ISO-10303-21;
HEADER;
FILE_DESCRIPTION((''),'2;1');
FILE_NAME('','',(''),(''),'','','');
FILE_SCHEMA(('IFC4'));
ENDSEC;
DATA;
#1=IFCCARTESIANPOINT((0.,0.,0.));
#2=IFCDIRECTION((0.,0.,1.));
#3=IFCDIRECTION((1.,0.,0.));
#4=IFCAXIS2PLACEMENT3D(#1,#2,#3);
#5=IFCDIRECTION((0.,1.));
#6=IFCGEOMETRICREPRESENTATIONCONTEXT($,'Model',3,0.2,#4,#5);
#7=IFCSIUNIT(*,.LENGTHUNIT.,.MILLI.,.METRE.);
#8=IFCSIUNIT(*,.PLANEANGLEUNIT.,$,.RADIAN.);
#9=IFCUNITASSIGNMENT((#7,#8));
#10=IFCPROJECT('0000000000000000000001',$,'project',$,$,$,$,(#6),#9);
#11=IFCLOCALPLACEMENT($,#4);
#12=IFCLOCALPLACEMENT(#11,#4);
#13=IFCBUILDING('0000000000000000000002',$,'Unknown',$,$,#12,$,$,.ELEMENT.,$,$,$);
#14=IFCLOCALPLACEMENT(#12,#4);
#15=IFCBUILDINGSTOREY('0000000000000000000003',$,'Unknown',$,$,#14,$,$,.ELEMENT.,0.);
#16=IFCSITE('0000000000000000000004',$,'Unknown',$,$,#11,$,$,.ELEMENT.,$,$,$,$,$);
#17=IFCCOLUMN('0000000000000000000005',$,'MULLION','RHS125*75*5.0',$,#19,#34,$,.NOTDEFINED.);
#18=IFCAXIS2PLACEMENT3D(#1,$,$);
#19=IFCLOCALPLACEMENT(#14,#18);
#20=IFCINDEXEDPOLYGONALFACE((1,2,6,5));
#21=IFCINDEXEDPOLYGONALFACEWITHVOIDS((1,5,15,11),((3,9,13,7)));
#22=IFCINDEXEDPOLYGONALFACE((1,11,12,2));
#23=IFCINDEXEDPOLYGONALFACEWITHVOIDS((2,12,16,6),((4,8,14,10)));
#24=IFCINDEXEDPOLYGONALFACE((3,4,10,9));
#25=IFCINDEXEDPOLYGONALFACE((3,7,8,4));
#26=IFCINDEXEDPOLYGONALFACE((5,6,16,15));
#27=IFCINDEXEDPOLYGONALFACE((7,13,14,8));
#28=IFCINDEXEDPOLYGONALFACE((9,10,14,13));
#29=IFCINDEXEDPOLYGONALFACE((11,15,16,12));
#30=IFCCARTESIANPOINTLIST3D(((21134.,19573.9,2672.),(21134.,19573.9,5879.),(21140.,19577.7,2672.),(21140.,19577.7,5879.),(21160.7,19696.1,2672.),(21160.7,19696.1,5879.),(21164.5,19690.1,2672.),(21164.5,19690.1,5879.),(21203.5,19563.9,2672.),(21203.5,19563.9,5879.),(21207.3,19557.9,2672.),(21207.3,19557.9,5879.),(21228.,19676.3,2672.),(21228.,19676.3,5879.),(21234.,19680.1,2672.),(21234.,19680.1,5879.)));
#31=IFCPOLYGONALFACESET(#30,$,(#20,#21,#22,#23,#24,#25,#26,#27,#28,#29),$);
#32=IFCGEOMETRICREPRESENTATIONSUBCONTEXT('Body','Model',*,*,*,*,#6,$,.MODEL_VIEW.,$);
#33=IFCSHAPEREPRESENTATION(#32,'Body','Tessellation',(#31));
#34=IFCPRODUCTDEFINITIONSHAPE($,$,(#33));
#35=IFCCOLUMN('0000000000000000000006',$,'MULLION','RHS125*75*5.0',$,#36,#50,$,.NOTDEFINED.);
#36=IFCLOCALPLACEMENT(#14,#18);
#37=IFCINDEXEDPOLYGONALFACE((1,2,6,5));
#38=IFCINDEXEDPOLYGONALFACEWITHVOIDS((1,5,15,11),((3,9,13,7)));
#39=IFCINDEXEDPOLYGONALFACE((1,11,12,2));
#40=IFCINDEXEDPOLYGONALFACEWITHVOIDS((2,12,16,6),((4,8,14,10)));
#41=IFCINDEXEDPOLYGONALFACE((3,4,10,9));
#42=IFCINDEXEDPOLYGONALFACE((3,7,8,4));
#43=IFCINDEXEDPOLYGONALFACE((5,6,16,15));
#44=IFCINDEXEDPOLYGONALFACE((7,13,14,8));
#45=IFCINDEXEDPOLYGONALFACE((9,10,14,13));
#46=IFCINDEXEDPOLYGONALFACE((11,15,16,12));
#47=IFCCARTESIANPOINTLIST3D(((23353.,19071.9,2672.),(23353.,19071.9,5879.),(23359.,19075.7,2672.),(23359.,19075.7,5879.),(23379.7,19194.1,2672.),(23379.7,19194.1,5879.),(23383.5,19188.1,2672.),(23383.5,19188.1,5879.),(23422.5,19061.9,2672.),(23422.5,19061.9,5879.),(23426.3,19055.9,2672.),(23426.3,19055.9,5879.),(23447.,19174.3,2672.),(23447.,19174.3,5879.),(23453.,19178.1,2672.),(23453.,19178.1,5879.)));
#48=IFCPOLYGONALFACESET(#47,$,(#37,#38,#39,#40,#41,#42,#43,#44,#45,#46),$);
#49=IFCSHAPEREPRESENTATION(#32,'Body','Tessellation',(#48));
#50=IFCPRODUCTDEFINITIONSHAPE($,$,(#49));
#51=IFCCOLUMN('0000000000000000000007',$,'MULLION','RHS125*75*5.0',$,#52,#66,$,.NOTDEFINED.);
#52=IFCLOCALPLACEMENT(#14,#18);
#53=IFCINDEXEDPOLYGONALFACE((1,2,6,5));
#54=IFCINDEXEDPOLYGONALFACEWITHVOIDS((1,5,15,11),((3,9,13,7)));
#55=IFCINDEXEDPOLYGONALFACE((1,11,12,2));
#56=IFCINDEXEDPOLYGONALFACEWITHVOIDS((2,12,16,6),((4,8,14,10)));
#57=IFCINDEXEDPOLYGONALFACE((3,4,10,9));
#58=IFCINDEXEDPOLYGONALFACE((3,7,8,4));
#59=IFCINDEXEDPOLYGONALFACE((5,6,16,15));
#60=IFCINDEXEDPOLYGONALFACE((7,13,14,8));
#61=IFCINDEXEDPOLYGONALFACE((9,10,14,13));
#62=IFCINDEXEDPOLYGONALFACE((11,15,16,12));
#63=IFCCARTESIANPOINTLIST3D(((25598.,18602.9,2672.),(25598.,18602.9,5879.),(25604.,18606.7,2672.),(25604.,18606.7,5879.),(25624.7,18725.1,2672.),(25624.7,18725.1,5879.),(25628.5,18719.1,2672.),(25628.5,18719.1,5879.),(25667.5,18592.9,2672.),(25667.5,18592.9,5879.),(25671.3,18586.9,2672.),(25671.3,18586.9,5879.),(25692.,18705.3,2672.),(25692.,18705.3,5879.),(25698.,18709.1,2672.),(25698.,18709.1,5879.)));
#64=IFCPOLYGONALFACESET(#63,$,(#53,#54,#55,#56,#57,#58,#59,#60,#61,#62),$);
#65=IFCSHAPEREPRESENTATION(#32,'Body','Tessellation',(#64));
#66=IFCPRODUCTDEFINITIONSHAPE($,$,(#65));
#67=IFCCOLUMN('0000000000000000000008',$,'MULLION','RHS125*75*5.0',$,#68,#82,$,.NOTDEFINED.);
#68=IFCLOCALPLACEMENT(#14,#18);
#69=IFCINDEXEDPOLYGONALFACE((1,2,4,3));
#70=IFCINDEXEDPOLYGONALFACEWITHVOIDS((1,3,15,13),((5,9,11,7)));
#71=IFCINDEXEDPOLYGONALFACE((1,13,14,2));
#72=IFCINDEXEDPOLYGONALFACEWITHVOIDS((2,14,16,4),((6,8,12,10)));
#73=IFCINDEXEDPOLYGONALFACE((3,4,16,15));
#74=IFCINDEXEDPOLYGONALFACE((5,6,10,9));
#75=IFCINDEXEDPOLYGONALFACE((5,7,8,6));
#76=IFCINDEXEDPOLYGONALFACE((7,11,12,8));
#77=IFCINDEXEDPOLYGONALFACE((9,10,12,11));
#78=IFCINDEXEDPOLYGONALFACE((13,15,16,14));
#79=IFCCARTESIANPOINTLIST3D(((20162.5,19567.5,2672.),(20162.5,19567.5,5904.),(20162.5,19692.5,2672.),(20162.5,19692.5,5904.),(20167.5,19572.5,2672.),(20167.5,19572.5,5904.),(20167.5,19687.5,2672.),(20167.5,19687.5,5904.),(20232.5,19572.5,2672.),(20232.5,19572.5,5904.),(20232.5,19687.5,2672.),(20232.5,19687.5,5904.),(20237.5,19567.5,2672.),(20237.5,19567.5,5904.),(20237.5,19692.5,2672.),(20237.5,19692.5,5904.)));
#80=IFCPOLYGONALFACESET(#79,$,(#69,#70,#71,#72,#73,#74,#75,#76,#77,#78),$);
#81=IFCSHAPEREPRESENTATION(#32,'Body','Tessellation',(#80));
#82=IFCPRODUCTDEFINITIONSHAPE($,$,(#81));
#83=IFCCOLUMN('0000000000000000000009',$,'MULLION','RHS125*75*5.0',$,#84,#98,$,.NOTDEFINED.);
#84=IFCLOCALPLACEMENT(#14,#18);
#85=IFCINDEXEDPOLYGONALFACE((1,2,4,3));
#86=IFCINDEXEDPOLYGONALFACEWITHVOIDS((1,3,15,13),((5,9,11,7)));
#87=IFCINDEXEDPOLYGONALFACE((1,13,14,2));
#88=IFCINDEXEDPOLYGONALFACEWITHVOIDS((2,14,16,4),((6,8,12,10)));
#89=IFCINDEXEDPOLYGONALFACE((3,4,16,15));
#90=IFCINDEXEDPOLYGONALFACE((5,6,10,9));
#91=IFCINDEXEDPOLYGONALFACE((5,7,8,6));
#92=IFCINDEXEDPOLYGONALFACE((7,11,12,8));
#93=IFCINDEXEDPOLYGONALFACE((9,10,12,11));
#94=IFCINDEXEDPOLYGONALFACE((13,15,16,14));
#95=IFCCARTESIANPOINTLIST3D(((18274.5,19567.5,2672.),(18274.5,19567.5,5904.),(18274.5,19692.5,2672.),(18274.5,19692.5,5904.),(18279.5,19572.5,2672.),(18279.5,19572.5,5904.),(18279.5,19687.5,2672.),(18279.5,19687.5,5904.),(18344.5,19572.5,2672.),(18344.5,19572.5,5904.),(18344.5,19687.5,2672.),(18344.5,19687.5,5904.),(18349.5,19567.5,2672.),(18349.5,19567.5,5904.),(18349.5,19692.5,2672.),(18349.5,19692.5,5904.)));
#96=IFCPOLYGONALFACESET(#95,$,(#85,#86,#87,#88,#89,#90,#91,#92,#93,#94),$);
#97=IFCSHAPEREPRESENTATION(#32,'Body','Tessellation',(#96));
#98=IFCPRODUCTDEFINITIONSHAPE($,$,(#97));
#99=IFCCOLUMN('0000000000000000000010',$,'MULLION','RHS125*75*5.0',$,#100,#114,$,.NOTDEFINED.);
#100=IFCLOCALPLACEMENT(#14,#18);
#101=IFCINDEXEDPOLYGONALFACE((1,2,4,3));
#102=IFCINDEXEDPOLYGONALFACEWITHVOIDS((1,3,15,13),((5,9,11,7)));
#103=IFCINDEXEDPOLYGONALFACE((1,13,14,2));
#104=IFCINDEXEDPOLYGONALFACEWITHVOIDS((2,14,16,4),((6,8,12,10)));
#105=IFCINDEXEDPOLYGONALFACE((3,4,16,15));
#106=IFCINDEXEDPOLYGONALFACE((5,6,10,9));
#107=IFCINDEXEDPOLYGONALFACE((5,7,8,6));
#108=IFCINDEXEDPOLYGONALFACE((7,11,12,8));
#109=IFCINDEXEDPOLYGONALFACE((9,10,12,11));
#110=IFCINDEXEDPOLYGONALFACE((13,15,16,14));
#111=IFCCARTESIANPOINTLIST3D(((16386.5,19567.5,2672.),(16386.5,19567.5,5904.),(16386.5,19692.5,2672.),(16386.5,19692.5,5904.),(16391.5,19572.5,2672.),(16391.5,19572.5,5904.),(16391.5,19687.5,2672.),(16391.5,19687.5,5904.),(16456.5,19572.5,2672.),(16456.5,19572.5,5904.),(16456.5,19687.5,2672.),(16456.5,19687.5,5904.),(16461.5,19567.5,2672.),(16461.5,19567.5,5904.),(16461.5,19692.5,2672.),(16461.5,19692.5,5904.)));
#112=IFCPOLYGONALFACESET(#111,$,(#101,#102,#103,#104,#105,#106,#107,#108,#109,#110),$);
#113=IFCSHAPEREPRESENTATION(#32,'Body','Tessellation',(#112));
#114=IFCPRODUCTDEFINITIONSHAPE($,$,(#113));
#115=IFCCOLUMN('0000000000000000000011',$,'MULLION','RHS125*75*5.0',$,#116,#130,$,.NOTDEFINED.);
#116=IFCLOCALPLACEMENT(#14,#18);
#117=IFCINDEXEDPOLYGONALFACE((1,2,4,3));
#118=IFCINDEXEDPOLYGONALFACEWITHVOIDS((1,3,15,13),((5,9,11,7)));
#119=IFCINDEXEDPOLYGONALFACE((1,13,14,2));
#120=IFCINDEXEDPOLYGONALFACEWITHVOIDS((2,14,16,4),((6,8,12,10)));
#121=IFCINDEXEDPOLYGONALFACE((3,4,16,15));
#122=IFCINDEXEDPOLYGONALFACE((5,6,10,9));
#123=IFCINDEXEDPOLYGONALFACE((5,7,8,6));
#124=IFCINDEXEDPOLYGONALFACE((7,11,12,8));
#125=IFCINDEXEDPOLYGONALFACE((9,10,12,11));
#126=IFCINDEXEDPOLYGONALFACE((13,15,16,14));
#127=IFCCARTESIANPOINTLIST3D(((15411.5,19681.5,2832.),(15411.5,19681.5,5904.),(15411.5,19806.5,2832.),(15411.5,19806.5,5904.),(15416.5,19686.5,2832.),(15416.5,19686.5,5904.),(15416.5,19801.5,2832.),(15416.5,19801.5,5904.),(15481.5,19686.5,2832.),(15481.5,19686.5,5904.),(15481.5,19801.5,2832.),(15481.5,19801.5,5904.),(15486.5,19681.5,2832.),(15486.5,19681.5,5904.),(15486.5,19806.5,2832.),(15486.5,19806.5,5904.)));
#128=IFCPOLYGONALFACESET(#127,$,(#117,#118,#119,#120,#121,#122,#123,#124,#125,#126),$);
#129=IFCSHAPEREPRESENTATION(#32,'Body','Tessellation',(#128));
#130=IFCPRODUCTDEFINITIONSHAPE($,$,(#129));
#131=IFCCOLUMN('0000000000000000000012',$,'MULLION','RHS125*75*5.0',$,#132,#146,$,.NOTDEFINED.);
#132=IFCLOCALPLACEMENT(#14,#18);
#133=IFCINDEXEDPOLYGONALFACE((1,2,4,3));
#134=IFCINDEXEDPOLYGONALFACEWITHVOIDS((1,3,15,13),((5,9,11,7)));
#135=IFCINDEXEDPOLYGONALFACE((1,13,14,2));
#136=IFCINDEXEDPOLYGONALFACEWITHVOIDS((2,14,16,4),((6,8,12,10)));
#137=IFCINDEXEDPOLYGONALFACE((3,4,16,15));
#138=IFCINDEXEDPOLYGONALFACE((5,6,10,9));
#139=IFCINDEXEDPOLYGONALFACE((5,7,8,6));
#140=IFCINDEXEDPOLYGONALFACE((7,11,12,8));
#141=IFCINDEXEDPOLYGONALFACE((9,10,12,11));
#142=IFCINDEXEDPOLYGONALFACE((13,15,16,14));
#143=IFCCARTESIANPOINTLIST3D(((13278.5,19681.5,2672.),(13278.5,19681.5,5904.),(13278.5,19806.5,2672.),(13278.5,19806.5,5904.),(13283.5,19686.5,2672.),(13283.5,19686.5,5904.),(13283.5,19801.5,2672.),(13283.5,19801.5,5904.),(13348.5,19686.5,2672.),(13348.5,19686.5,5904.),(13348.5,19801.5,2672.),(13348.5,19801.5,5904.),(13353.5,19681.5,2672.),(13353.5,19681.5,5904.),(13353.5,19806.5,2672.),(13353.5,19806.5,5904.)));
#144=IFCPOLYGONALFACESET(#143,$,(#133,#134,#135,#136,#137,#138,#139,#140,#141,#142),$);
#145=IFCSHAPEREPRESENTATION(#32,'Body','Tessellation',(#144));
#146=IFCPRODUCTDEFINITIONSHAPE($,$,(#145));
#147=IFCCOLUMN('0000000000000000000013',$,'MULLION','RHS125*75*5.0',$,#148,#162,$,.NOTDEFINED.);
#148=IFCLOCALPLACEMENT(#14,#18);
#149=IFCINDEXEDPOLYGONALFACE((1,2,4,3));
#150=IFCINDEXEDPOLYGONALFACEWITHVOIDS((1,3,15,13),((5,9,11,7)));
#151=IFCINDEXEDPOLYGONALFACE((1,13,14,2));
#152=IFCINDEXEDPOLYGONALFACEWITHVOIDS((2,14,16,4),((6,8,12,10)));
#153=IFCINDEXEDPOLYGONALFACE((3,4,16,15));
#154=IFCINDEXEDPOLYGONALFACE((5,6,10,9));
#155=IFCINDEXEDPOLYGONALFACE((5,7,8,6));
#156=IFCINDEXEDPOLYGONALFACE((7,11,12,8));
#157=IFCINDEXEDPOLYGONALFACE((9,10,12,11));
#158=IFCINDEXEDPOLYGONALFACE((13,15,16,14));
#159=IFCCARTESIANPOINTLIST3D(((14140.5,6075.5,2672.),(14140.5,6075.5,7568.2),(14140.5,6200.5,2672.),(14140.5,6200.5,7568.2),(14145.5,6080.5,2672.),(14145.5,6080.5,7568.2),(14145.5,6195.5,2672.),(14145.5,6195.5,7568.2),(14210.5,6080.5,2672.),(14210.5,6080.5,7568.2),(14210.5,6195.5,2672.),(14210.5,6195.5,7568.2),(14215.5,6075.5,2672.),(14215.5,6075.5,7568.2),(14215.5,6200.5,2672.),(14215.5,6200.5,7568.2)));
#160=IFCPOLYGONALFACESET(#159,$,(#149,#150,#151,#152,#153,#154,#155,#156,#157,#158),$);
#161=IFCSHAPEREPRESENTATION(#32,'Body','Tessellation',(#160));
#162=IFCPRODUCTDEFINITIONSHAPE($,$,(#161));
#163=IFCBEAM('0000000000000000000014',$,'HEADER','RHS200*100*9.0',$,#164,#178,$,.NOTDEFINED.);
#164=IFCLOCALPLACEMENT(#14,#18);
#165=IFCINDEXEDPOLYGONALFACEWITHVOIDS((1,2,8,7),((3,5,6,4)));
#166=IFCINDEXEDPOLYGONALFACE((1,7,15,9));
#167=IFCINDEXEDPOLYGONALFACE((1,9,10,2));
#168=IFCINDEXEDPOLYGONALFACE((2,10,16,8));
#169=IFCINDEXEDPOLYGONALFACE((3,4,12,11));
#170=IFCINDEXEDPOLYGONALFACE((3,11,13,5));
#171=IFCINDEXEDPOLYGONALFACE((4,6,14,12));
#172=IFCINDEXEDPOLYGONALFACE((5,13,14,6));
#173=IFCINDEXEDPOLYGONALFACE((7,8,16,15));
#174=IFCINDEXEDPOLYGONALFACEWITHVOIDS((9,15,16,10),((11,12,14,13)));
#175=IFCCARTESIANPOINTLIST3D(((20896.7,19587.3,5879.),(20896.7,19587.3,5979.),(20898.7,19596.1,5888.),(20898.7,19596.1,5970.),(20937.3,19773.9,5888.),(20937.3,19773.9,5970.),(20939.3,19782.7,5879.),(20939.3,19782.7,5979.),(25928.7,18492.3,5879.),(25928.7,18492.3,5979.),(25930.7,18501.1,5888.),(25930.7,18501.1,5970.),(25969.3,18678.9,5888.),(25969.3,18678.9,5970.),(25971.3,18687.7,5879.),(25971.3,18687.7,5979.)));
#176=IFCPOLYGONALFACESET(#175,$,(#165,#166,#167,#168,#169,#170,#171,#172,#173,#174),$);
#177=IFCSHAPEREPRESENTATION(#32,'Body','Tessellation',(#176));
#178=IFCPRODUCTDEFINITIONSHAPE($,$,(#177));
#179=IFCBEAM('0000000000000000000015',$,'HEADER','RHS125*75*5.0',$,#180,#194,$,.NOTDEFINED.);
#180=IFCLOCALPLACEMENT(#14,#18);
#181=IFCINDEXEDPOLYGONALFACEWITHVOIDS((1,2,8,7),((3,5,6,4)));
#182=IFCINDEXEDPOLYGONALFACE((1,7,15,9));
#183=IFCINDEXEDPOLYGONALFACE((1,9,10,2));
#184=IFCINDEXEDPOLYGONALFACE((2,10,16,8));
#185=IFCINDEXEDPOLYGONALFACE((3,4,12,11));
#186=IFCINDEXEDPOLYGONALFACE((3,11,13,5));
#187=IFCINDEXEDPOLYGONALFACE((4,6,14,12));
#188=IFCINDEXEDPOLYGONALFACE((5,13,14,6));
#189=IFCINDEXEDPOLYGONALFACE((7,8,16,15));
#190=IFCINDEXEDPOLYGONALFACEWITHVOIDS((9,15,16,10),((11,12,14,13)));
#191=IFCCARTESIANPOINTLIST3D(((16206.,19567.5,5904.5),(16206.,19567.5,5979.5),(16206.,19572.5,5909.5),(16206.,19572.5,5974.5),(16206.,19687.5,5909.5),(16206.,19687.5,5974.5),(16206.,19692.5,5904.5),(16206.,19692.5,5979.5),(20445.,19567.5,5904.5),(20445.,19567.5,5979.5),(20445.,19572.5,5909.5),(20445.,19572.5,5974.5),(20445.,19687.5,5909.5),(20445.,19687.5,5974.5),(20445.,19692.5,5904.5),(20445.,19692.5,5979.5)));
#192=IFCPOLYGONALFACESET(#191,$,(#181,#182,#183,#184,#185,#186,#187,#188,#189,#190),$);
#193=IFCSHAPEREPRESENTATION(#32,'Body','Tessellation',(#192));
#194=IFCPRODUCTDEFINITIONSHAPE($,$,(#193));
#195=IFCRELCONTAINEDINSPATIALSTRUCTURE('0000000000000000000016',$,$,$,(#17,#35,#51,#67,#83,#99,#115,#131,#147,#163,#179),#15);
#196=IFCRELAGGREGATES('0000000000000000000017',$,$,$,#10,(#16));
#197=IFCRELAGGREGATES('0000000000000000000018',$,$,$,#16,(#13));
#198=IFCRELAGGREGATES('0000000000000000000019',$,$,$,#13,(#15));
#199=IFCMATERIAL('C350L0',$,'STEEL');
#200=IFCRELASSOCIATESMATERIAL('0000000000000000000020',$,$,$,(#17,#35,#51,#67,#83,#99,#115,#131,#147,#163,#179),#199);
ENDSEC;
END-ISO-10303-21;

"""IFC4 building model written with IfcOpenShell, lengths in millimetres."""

from ifc_helpers import new_model, si_unit, direction, frame, origin_with_axes, place, context, subcontext, project, spatial, line, indexed_curve, outline, extrude, material, element, save


model = new_model("IFC4")

# Units and contexts
model_context = context("Model", 3, precision=0.2, world=origin_with_axes(), true_north=direction((0.0, 1.0)))
body_context = subcontext(model_context, "Body", "Model", "MODEL_VIEW")
ifc_project = project(units=[si_unit("LENGTHUNIT", "METRE", prefix="MILLI"), si_unit("PLANEANGLEUNIT", "RADIAN")], contexts=[model_context])

# Site, building, storey
site_placement = place(None, origin_with_axes())
site = spatial("IfcSite", under=ifc_project, at=site_placement, Name="Unknown", CompositionType="ELEMENT")
building_placement = place(site_placement, origin_with_axes())
building = spatial("IfcBuilding", under=site, at=building_placement, Name="Unknown", CompositionType="ELEMENT")
storey_placement = place(building_placement, origin_with_axes())
storey = spatial("IfcBuildingStorey", under=building, at=storey_placement, Name="Unknown", CompositionType="ELEMENT", Elevation=0.0)

# Columns
ifc_material_1 = material(Name="C350L0", Category="STEEL")
for number, where, z_axis, x_axis, name in (
    (1, (21184.0, 19627.0, 2672.0), (0.977046, -0.21303, 0.0), (0.0, 0.0, 1.0), "MULLION"),
    (2, (23403.0, 19125.0, 2672.0), (0.977046, -0.21303, 0.0), (0.0, 0.0, 1.0), "MULLION"),
    (3, (25648.0, 18656.0, 2672.0), (0.977046, -0.21303, 0.0), (0.0, 0.0, 1.0), "MULLION"),
):
    element("IfcColumn", number, at=place(storey_placement, frame(where, z_axis=z_axis, x_axis=x_axis)), inside=storey, material=ifc_material_1, Name=name, Description="RHS125*75*5.0", PredefinedType="NOTDEFINED", context=body_context, shape_type="SolidModel", body=[
        extrude(outline(indexed_curve([(-37.5, -62.5), (37.5, -62.5), (37.5, 62.5), (-37.5, 62.5)], segments=[line(1, 2, 3, 4, 1)]), holes=[indexed_curve([(-32.5, -57.5), (-32.5, 57.5), (32.5, 57.5), (32.5, -57.5)], segments=[line(1, 2, 3, 4, 1)])]), frame((0.0, 0.0, 0.0), z_axis=(-1.0, 0.0, 0.0), x_axis=(0.0, 0.0, 1.0)), (0.0, 0.0, -1.0), 3207.0),
    ])
for number, where, z_axis, x_axis, name in (
    (4, (20200.0, 19630.0, 2672.0), (1.0, 0.0, 0.0), (0.0, 0.0, 1.0), "MULLION"),
    (5, (18312.0, 19630.0, 2672.0), (1.0, 0.0, 0.0), (0.0, 0.0, 1.0), "MULLION"),
    (6, (16424.0, 19630.0, 2672.0), (1.0, 0.0, 0.0), (0.0, 0.0, 1.0), "MULLION"),
):
    element("IfcColumn", number, at=place(storey_placement, frame(where, z_axis=z_axis, x_axis=x_axis)), inside=storey, material=ifc_material_1, Name=name, Description="RHS125*75*5.0", PredefinedType="NOTDEFINED", context=body_context, shape_type="SolidModel", body=[
        extrude(outline(indexed_curve([(-37.5, -62.5), (37.5, -62.5), (37.5, 62.5), (-37.5, 62.5)], segments=[line(1, 2, 3, 4, 1)]), holes=[indexed_curve([(-32.5, -57.5), (-32.5, 57.5), (32.5, 57.5), (32.5, -57.5)], segments=[line(1, 2, 3, 4, 1)])]), frame((0.0, 0.0, 0.0), z_axis=(-1.0, 0.0, 0.0), x_axis=(0.0, 0.0, 1.0)), (0.0, 0.0, -1.0), 3232.0),
    ])
column_1_placement = place(storey_placement, frame((15449.0, 19744.0, 2832.0), z_axis=(1.0, 0.0, 0.0), x_axis=(0.0, 0.0, 1.0)))
element("IfcColumn", 7, at=column_1_placement, inside=storey, material=ifc_material_1, Name="MULLION", Description="RHS125*75*5.0", PredefinedType="NOTDEFINED", context=body_context, shape_type="SolidModel", body=[
    extrude(outline(indexed_curve([(-37.5, -62.5), (37.5, -62.5), (37.5, 62.5), (-37.5, 62.5)], segments=[line(1, 2, 3, 4, 1)]), holes=[indexed_curve([(-32.5, -57.5), (-32.5, 57.5), (32.5, 57.5), (32.5, -57.5)], segments=[line(1, 2, 3, 4, 1)])]), frame((0.0, 0.0, 0.0), z_axis=(-1.0, 0.0, 0.0), x_axis=(0.0, 0.0, 1.0)), (0.0, 0.0, -1.0), 3072.0),
])
column_2_placement = place(storey_placement, frame((13316.0, 19744.0, 2672.0), z_axis=(1.0, 0.0, 0.0), x_axis=(0.0, 0.0, 1.0)))
element("IfcColumn", 8, at=column_2_placement, inside=storey, material=ifc_material_1, Name="MULLION", Description="RHS125*75*5.0", PredefinedType="NOTDEFINED", context=body_context, shape_type="SolidModel", body=[
    extrude(outline(indexed_curve([(-37.5, -62.5), (37.5, -62.5), (37.5, 62.5), (-37.5, 62.5)], segments=[line(1, 2, 3, 4, 1)]), holes=[indexed_curve([(-32.5, -57.5), (-32.5, 57.5), (32.5, 57.5), (32.5, -57.5)], segments=[line(1, 2, 3, 4, 1)])]), frame((0.0, 0.0, 0.0), z_axis=(-1.0, 0.0, 0.0), x_axis=(0.0, 0.0, 1.0)), (0.0, 0.0, -1.0), 3232.0),
])
column_3_placement = place(storey_placement, frame((14178.0, 6138.0, 2672.0), z_axis=(1.0, 0.0, 0.0), x_axis=(0.0, 0.0, 1.0)))
element("IfcColumn", 9, at=column_3_placement, inside=storey, material=ifc_material_1, Name="MULLION", Description="RHS125*75*5.0", PredefinedType="NOTDEFINED", context=body_context, shape_type="SolidModel", body=[
    extrude(outline(indexed_curve([(-37.5, -62.5), (37.5, -62.5), (37.5, 62.5), (-37.5, 62.5)], segments=[line(1, 2, 3, 4, 1)]), holes=[indexed_curve([(-32.5, -57.5), (-32.5, 57.5), (32.5, 57.5), (32.5, -57.5)], segments=[line(1, 2, 3, 4, 1)])]), frame((0.0, 0.0, 0.0), z_axis=(-1.0, 0.0, 0.0), x_axis=(0.0, 0.0, 1.0)), (0.0, 0.0, -1.0), 4896.2),
])

# Beams
beam_1_placement = place(storey_placement, frame((20918.0, 19685.0, 5929.0), z_axis=(0.0, 0.0, 1.0), x_axis=(0.977133, -0.212631, 0.0)))
element("IfcBeam", 10, at=beam_1_placement, inside=storey, material=ifc_material_1, Name="HEADER", Description="RHS200*100*9.0", PredefinedType="NOTDEFINED", context=body_context, shape_type="SolidModel", body=[
    extrude(outline(indexed_curve([(-50.0, -100.0), (50.0, -100.0), (50.0, 100.0), (-50.0, 100.0)], segments=[line(1, 2, 3, 4, 1)]), holes=[indexed_curve([(-41.0, -91.0), (-41.0, 91.0), (41.0, 91.0), (41.0, -91.0)], segments=[line(1, 2, 3, 4, 1)])]), frame((0.0, 0.0, 0.0), z_axis=(-1.0, 0.0, 0.0), x_axis=(0.0, 0.0, 1.0)), (0.0, 0.0, -1.0), 5149.8),
])
beam_2_placement = place(storey_placement, frame((16206.0, 19630.0, 5942.0), z_axis=(0.0, 0.0, 1.0), x_axis=(1.0, 0.0, 0.0)))
element("IfcBeam", 11, at=beam_2_placement, inside=storey, material=ifc_material_1, Name="HEADER", Description="RHS125*75*5.0", PredefinedType="NOTDEFINED", context=body_context, shape_type="SolidModel", body=[
    extrude(outline(indexed_curve([(-37.5, -62.5), (37.5, -62.5), (37.5, 62.5), (-37.5, 62.5)], segments=[line(1, 2, 3, 4, 1)]), holes=[indexed_curve([(-32.5, -57.5), (-32.5, 57.5), (32.5, 57.5), (32.5, -57.5)], segments=[line(1, 2, 3, 4, 1)])]), frame((0.0, 0.0, 0.0), z_axis=(-1.0, 0.0, 0.0), x_axis=(0.0, 0.0, 1.0)), (0.0, 0.0, -1.0), 4239.0),
])

save(model, "model.ifc")
